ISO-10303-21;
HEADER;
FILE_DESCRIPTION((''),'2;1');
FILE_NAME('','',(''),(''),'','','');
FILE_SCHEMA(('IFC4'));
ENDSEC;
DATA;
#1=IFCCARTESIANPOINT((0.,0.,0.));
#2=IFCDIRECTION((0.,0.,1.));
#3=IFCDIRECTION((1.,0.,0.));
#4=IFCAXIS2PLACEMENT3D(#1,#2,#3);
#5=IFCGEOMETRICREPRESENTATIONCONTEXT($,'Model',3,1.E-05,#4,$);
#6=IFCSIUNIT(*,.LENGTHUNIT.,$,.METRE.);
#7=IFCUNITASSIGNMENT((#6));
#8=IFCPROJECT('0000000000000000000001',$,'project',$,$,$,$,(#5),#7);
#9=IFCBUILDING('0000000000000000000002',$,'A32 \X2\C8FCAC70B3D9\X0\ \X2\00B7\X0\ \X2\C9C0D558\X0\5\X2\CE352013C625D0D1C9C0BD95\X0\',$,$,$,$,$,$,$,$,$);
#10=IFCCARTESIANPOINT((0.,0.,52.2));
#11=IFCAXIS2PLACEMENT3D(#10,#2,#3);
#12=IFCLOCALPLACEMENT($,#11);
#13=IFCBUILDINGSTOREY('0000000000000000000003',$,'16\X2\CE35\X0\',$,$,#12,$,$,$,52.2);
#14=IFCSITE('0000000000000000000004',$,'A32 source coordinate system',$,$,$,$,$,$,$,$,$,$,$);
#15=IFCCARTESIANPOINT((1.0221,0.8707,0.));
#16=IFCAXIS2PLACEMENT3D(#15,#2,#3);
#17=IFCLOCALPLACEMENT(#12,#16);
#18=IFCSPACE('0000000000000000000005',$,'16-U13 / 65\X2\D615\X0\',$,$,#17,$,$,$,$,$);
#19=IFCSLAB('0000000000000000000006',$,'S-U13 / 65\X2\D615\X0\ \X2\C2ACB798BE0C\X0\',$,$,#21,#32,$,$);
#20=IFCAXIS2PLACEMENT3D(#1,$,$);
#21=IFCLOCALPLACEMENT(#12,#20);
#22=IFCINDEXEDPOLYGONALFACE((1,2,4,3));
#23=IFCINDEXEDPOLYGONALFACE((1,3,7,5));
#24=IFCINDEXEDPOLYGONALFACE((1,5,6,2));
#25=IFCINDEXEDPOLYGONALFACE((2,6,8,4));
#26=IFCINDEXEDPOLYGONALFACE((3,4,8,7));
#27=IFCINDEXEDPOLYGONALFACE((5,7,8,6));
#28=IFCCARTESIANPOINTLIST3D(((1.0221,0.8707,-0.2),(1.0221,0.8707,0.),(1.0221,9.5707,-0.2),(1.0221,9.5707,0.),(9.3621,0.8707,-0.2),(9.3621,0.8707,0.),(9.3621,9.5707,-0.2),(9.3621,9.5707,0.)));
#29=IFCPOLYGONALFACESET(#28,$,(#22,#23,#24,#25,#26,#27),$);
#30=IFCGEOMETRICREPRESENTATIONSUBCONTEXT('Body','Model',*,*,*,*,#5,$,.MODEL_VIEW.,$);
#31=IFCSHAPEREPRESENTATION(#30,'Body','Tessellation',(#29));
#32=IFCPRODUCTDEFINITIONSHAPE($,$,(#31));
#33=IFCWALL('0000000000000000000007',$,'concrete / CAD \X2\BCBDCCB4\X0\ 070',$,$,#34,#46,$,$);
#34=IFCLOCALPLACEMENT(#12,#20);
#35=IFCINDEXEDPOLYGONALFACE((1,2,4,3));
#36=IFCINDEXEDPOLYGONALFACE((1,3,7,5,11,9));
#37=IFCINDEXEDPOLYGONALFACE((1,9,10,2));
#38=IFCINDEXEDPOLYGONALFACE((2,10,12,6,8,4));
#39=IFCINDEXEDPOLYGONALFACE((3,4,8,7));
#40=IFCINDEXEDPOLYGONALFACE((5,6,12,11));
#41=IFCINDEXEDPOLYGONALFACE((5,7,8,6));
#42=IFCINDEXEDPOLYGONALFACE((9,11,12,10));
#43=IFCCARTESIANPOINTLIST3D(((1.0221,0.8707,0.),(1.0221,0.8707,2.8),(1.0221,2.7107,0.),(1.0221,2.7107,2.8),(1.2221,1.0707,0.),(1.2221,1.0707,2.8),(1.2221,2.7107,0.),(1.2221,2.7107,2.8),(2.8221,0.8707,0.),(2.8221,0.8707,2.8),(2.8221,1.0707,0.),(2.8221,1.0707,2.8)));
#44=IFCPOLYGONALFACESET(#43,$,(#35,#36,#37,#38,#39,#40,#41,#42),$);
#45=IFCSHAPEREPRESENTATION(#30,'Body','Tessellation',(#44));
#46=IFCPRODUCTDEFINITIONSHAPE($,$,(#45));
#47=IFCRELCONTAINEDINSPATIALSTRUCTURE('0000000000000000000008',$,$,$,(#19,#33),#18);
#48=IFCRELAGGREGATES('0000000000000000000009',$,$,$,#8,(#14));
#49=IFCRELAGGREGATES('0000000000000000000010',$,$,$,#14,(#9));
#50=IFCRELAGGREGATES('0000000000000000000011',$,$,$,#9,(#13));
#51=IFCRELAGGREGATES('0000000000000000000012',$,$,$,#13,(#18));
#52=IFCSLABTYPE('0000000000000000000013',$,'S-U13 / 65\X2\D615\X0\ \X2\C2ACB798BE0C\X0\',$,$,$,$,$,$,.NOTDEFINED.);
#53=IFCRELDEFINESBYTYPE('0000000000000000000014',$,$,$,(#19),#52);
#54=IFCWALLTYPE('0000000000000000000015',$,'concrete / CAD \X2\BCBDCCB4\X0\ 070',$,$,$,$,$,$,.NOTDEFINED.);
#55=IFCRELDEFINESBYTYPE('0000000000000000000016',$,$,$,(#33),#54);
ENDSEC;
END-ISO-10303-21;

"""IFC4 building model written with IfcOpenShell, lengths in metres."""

from ifc_helpers import new_model, si_unit, frame, origin, origin_with_axes, place, context, subcontext, project, spatial, polyline, outline, extrude, source, transform, mapped, type_object, type_shapes, element, save


model = new_model("IFC4")

# Units and contexts
model_context = context("Model", 3, precision=1e-05, world=origin_with_axes())
body_context = subcontext(model_context, "Body", "Model", "MODEL_VIEW")
ifc_project = project(units=[si_unit("LENGTHUNIT", "METRE")], contexts=[model_context])

# Site, building, storey, space
storey_placement = place(None, frame((0.0, 0.0, 52.2), z_axis=(0.0, 0.0, 1.0), x_axis=(1.0, 0.0, 0.0)))
space_placement = place(storey_placement, frame((1.0221, 0.8707, 0.0), z_axis=(0.0, 0.0, 1.0), x_axis=(1.0, 0.0, 0.0)))
site = spatial("IfcSite", under=ifc_project, Name="A32 source coordinate system")
building = spatial("IfcBuilding", under=site, Name="A32 주거동 · 지하5층–옥탑지붕")
storey = spatial("IfcBuildingStorey", under=building, at=storey_placement, Name="16층", Elevation=52.2)
space = spatial("IfcSpace", under=storey, at=space_placement, Name="16-U13 / 65형")

# Slab
slab_type = type_object("IfcSlabType", Name="S-U13 / 65형 슬래브", PredefinedType="NOTDEFINED")
shared_shape_1 = source(origin(), body_context, "Body", "SweptSolid", [
    extrude(outline(polyline([(0.0, 0.0), (0.0, 8.7), (8.34, 8.7), (8.34, 0.0), (0.0, 0.0)])), frame((0.0, 0.0, -0.2)), (0.0, 0.0, 1.0), 0.2),
])
type_shapes(slab_type, [shared_shape_1])
slab_placement = place(space_placement, origin_with_axes())
element("IfcSlab", 1, at=slab_placement, inside=space, type_object=slab_type, Name="S-U13 / 65형 슬래브", context=body_context, shape_type="MappedRepresentation", body=[
    mapped(shared_shape_1, transform((0.0, 0.0, 0.0), scale=1.0)),
])

# Wall
wall_type_1 = type_object("IfcWallType", Name="concrete / CAD 벽체 070", PredefinedType="NOTDEFINED")
shared_shape_2 = source(origin(), body_context, "Body", "SweptSolid", [
    extrude(outline(polyline([(0.2, 1.84), (0.2, 0.2), (1.8, 0.2), (1.8, 0.0), (0.0, 0.0), (0.0, 1.84), (0.2, 1.84)])), origin(), (0.0, 0.0, 1.0), 2.8),
])
type_shapes(wall_type_1, [shared_shape_2])
wall_1_placement = place(space_placement, origin_with_axes())
element("IfcWall", 2, at=wall_1_placement, inside=space, type_object=wall_type_1, Name="concrete / CAD 벽체 070", context=body_context, shape_type="MappedRepresentation", body=[
    mapped(shared_shape_2, transform((0.0, 0.0, 0.0), scale=1.0)),
])

save(model, "model.ifc")
